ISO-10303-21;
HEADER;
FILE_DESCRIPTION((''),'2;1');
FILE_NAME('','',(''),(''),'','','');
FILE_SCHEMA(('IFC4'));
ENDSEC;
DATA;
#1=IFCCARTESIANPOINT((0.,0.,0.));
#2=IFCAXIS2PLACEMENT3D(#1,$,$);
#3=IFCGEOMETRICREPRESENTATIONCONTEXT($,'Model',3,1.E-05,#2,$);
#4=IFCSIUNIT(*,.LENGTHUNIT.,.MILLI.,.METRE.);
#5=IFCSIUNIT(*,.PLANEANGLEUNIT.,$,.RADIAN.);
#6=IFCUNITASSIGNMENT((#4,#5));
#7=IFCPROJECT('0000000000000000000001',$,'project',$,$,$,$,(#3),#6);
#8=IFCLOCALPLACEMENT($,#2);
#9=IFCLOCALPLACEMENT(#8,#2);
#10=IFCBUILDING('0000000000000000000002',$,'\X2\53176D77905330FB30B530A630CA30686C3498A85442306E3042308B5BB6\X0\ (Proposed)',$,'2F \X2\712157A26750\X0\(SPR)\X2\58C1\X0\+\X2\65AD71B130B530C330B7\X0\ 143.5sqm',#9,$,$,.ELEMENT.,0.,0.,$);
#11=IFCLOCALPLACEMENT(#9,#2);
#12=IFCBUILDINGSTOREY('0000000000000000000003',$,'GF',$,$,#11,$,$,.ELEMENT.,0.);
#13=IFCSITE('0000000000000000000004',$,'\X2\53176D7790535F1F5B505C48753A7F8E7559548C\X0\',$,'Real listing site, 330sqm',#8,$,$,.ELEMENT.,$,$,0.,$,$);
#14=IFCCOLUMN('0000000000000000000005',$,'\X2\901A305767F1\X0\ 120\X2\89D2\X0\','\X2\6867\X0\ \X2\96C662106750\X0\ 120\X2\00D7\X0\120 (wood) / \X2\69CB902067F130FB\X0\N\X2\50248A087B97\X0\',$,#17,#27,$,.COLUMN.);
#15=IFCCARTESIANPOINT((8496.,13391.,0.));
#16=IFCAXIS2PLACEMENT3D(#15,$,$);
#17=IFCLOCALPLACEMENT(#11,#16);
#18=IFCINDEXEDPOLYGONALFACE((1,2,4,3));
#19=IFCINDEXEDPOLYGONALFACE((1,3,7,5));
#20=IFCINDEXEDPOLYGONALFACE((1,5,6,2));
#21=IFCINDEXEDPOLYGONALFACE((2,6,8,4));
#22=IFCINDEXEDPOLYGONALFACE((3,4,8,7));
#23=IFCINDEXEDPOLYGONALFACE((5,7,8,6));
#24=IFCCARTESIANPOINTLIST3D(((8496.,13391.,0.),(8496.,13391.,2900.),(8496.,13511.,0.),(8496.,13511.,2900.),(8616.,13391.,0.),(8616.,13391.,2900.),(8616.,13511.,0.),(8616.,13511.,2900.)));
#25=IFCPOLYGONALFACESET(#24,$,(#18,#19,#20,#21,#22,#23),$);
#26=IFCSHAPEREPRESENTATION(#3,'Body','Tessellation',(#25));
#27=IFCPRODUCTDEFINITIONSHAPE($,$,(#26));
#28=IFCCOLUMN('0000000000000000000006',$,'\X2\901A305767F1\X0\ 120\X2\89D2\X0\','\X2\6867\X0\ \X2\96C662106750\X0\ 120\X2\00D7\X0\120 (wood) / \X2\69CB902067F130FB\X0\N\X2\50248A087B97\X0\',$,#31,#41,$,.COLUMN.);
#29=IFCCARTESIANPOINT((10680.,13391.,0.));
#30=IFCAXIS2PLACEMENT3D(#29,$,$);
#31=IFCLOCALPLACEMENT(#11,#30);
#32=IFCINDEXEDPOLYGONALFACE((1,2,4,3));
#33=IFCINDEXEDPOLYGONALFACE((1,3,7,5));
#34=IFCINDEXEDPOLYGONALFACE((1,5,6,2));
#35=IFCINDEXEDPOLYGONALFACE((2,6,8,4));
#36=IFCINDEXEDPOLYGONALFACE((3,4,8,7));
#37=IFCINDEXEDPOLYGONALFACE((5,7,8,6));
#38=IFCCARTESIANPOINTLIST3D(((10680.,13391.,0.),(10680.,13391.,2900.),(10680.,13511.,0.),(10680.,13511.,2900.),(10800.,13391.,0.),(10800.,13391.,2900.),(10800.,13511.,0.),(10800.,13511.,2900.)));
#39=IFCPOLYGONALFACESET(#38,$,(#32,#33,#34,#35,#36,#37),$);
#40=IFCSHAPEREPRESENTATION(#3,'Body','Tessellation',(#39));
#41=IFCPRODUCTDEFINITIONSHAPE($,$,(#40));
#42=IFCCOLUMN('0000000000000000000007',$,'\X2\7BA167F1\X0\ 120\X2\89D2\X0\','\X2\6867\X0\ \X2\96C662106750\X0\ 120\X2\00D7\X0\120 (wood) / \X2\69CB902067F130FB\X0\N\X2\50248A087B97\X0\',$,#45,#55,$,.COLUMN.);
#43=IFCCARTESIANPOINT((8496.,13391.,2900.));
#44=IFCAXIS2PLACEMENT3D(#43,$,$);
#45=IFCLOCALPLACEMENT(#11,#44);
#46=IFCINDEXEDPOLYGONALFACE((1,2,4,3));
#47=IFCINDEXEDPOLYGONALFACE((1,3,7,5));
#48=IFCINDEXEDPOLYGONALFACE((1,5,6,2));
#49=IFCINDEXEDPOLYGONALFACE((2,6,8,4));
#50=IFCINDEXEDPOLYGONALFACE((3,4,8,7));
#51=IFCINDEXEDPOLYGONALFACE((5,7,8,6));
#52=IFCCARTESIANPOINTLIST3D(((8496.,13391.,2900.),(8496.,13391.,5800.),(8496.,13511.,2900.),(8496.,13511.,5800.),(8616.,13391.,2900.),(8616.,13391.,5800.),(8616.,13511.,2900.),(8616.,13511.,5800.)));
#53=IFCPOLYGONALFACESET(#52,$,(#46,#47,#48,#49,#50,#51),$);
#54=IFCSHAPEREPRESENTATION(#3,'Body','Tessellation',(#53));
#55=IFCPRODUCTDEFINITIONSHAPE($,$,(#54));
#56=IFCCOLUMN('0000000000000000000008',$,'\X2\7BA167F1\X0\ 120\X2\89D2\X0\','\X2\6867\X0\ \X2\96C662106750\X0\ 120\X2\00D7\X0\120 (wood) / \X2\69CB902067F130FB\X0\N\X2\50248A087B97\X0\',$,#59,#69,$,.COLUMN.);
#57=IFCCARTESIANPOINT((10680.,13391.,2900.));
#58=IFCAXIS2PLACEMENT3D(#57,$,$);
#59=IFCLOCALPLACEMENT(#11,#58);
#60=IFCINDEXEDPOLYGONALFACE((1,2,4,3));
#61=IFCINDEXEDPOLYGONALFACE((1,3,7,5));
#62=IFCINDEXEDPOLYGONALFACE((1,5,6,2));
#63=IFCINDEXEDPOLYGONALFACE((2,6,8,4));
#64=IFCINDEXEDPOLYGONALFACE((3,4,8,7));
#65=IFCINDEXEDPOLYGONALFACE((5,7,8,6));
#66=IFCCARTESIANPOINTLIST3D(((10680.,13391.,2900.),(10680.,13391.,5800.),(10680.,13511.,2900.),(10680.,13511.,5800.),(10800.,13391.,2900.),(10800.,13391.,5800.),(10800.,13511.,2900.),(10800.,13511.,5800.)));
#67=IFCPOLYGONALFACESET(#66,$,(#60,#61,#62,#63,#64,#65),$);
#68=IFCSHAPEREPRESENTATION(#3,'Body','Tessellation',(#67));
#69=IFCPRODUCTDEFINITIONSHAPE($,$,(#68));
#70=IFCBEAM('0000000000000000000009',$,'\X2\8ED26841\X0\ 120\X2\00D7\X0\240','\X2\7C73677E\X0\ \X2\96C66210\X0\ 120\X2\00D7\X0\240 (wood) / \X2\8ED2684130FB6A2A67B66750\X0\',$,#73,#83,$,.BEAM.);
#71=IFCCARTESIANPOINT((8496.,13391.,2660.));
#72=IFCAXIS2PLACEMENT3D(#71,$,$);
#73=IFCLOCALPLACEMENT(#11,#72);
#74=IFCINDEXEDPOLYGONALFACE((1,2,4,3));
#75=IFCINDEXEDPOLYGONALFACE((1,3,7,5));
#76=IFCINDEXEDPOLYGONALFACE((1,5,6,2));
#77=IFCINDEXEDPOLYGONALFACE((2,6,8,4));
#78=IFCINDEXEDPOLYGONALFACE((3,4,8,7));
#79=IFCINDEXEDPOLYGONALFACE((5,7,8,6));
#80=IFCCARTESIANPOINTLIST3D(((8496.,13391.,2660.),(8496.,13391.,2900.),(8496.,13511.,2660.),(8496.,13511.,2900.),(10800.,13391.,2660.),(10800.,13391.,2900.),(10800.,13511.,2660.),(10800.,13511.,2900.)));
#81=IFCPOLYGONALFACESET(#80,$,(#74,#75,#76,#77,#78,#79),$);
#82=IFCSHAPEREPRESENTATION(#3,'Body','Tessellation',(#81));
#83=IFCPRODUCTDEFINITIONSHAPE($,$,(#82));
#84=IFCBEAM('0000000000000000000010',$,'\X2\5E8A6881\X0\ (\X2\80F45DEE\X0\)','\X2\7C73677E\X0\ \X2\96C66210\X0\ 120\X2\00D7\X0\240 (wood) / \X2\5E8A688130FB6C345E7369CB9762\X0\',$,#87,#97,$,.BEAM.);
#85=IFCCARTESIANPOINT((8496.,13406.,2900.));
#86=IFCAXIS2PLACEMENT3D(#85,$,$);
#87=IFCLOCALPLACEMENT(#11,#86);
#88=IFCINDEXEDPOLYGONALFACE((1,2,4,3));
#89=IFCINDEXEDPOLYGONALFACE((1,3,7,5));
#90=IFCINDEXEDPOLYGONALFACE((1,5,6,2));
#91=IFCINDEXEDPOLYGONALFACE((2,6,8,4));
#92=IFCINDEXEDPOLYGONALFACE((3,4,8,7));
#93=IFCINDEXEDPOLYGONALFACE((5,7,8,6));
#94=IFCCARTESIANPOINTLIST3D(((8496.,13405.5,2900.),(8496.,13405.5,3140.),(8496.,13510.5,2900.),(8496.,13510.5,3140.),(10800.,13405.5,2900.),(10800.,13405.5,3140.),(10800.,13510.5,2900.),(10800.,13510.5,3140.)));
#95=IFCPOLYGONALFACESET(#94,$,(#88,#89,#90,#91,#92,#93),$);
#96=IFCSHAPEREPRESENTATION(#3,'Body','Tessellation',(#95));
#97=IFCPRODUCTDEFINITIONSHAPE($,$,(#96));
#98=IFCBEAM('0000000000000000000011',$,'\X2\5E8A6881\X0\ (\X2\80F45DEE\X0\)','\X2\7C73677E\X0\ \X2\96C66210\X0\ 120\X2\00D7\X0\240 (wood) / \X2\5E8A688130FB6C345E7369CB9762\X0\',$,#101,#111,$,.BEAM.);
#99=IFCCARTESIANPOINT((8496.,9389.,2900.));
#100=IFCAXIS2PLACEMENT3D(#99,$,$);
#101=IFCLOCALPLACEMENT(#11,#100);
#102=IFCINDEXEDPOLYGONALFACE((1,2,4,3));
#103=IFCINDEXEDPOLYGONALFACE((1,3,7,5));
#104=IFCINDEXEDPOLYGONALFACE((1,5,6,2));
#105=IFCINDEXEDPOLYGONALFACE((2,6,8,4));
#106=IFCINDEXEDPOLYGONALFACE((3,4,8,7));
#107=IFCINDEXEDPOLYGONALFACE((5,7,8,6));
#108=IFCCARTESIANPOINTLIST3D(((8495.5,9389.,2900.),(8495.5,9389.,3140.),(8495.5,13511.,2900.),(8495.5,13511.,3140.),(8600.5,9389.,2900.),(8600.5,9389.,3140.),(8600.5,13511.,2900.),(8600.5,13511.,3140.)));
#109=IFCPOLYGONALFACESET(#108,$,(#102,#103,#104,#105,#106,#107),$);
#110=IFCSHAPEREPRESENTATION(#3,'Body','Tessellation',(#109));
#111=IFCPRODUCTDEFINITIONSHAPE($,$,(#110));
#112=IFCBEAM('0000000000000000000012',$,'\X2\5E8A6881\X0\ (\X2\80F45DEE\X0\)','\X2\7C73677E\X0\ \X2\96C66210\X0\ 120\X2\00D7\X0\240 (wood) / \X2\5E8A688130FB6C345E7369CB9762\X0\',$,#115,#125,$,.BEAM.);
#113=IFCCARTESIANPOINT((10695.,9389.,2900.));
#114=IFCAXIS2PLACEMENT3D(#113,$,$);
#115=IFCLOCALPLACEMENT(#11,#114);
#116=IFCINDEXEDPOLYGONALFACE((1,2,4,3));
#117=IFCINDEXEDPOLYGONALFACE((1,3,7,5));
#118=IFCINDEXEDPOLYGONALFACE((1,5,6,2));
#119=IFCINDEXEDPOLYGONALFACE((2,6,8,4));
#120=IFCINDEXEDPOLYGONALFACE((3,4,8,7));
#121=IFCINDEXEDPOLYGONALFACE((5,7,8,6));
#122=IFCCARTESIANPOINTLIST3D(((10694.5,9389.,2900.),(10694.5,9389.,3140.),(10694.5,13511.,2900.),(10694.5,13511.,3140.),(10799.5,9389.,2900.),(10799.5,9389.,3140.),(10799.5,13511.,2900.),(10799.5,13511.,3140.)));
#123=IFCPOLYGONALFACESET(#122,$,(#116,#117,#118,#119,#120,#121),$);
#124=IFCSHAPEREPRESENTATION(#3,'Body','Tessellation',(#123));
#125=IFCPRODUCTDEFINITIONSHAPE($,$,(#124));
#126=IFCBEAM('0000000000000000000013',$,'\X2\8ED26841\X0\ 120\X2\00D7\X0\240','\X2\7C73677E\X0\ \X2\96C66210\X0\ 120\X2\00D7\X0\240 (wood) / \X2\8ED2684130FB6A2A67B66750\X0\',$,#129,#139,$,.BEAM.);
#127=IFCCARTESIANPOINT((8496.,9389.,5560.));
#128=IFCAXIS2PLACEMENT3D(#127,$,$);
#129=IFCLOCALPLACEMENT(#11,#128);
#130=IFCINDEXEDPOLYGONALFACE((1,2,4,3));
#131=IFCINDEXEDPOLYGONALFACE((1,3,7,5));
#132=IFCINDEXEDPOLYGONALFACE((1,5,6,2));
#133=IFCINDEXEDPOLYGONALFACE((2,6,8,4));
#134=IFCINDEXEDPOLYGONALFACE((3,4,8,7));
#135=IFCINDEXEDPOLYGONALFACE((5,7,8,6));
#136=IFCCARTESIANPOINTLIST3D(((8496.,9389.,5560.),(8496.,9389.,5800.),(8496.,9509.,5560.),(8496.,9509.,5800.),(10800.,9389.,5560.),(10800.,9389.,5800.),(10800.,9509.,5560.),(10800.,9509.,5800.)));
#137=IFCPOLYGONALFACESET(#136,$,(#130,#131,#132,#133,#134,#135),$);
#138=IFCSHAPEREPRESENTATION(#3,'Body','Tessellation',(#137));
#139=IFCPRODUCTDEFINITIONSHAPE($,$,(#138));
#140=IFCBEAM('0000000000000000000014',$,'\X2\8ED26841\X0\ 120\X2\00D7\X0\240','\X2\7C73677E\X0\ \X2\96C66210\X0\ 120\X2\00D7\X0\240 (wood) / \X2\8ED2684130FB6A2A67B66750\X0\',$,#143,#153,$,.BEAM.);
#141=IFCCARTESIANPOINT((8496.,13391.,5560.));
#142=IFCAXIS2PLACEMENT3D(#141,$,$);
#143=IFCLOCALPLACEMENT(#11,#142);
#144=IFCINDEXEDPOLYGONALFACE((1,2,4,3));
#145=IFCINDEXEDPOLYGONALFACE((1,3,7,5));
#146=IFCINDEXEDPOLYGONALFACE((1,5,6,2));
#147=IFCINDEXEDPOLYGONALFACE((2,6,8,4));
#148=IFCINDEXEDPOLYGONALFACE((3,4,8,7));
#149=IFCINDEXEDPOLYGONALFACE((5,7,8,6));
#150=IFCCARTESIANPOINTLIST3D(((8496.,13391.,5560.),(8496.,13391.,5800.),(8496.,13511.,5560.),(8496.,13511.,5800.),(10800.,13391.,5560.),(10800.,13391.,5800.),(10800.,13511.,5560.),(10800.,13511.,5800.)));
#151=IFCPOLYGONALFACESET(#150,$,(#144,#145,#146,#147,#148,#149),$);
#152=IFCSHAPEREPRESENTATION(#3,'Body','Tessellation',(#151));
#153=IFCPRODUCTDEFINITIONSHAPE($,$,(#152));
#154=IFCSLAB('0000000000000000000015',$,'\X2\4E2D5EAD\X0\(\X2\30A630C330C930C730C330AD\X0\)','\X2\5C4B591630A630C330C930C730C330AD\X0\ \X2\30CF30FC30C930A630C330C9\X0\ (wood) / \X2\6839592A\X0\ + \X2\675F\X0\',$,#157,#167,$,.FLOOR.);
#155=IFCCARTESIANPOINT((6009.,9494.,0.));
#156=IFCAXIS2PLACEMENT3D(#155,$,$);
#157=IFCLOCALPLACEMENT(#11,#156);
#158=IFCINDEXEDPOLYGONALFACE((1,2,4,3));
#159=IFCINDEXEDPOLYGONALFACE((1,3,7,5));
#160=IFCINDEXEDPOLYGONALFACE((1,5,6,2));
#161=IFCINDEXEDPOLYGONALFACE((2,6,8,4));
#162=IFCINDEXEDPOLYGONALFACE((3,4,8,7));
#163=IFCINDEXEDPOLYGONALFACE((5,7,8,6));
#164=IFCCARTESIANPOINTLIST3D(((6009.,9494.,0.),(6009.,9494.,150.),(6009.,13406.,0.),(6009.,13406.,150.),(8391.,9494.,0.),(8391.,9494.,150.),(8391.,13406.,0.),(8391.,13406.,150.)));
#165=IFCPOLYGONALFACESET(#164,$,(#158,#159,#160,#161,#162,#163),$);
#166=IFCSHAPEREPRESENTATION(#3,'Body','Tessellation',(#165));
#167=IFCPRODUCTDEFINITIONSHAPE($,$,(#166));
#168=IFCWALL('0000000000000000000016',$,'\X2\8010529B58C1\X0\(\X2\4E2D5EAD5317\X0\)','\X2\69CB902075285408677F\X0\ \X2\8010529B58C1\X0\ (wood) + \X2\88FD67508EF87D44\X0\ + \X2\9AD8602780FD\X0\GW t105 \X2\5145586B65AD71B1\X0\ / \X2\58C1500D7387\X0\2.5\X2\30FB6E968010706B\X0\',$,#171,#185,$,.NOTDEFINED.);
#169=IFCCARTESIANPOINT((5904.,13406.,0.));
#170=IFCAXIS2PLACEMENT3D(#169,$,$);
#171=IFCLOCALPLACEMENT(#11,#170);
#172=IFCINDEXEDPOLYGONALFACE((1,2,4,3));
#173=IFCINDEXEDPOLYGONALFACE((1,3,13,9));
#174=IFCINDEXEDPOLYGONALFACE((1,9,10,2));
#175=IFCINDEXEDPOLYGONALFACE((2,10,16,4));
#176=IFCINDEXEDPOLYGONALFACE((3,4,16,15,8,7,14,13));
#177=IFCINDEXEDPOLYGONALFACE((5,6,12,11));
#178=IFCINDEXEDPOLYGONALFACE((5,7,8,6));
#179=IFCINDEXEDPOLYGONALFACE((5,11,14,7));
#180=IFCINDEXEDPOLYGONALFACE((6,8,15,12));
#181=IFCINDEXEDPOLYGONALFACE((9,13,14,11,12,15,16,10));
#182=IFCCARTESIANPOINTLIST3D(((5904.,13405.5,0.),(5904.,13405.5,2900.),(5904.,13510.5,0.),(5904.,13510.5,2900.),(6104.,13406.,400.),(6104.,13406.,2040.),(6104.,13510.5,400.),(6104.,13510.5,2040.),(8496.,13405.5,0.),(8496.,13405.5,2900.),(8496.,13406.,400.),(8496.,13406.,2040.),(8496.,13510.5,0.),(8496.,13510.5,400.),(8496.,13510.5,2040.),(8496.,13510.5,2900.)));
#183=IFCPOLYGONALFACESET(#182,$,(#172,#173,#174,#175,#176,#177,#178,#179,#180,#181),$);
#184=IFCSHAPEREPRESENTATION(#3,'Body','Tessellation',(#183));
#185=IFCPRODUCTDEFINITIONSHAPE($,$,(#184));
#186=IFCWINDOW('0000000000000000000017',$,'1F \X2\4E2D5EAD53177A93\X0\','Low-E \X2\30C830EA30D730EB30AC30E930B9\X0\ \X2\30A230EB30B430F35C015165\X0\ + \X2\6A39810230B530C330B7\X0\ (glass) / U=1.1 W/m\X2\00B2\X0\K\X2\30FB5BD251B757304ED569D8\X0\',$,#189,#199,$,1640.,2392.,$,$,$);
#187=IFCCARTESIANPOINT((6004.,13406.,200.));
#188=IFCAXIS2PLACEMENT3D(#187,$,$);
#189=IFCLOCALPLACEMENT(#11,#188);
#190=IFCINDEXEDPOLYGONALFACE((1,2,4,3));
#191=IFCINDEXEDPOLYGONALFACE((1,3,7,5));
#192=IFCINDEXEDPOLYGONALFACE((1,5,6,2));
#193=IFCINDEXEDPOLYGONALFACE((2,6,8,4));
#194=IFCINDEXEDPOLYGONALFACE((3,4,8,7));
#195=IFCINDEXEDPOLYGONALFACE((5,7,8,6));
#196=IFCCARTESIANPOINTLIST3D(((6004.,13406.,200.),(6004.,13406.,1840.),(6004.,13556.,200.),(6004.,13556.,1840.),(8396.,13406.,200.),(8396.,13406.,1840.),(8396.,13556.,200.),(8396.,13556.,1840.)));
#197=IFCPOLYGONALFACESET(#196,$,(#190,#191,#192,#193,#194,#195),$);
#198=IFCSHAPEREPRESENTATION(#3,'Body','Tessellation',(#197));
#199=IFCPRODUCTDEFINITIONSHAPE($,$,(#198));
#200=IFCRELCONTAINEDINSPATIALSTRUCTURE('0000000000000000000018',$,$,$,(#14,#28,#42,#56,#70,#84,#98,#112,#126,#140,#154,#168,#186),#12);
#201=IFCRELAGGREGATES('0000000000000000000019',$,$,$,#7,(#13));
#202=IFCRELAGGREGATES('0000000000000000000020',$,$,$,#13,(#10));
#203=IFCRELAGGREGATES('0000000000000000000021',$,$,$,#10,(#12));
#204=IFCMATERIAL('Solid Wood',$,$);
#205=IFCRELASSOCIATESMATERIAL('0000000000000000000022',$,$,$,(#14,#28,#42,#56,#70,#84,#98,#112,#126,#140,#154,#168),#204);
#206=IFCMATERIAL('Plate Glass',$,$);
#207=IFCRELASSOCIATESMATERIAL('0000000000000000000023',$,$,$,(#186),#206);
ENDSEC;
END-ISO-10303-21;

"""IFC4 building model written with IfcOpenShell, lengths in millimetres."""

from ifc_helpers import new_model, si_unit, frame, frame_2d, origin, place, context, project, spatial, rectangle, extrude, material, element, fill, save


model = new_model("IFC4")

# Units and contexts
model_context = context("Model", 3, precision=1e-05, world=origin())
ifc_project = project(units=[si_unit("LENGTHUNIT", "METRE", prefix="MILLI"), si_unit("PLANEANGLEUNIT", "RADIAN")], contexts=[model_context])

# Site, building, storey
site_placement = place(None, origin())
site = spatial("IfcSite", under=ifc_project, at=site_placement, Name="北海道弟子屈町美留和", ObjectType="Real listing site, 330sqm", CompositionType="ELEMENT", RefElevation=0.0)
building_placement = place(site_placement, origin())
building = spatial("IfcBuilding", under=site, at=building_placement, Name="北海道・サウナと水風呂のある家 (Proposed)", ObjectType="2F 無垢材(SPR)壁+断熱サッシ 143.5sqm", CompositionType="ELEMENT", ElevationOfRefHeight=0.0, ElevationOfTerrain=0.0)
storey_placement = place(building_placement, origin())
storey = spatial("IfcBuildingStorey", under=building, at=storey_placement, Name="GF", CompositionType="ELEMENT", Elevation=0.0)

# Columns
ifc_material_1 = material(Name="Solid Wood")
column_1_placement = place(storey_placement, frame((8496.0, 13391.0, 0.0)))
element("IfcColumn", 1, at=column_1_placement, inside=storey, material=ifc_material_1, Name="通し柱 120角", Description="桧 集成材 120×120 (wood) / 構造柱・N値計算", PredefinedType="COLUMN", context=model_context, shape_type="SweptSolid", body=[
    extrude(rectangle(XDim=120.0, YDim=120.0, at=frame_2d((60.0, 60.0))), frame((8496.0, 13391.0, 0.0)), (0.0, 0.0, 1.0), 2900.0),
])
column_2_placement = place(storey_placement, frame((10680.0, 13391.0, 0.0)))
element("IfcColumn", 2, at=column_2_placement, inside=storey, material=ifc_material_1, Name="通し柱 120角", Description="桧 集成材 120×120 (wood) / 構造柱・N値計算", PredefinedType="COLUMN", context=model_context, shape_type="SweptSolid", body=[
    extrude(rectangle(XDim=120.0, YDim=120.0, at=frame_2d((60.0, 60.0))), frame((10680.0, 13391.0, 0.0)), (0.0, 0.0, 1.0), 2900.0),
])
column_3_placement = place(storey_placement, frame((8496.0, 13391.0, 2900.0)))
element("IfcColumn", 3, at=column_3_placement, inside=storey, material=ifc_material_1, Name="管柱 120角", Description="桧 集成材 120×120 (wood) / 構造柱・N値計算", PredefinedType="COLUMN", context=model_context, shape_type="SweptSolid", body=[
    extrude(rectangle(XDim=120.0, YDim=120.0, at=frame_2d((60.0, 60.0))), frame((8496.0, 13391.0, 2900.0)), (0.0, 0.0, 1.0), 2900.0),
])
column_4_placement = place(storey_placement, frame((10680.0, 13391.0, 2900.0)))
element("IfcColumn", 4, at=column_4_placement, inside=storey, material=ifc_material_1, Name="管柱 120角", Description="桧 集成材 120×120 (wood) / 構造柱・N値計算", PredefinedType="COLUMN", context=model_context, shape_type="SweptSolid", body=[
    extrude(rectangle(XDim=120.0, YDim=120.0, at=frame_2d((60.0, 60.0))), frame((10680.0, 13391.0, 2900.0)), (0.0, 0.0, 1.0), 2900.0),
])

# Beams
beam_1_placement = place(storey_placement, frame((8496.0, 13391.0, 2660.0)))
element("IfcBeam", 5, at=beam_1_placement, inside=storey, material=ifc_material_1, Name="軒桁 120×240", Description="米松 集成 120×240 (wood) / 軒桁・横架材", PredefinedType="BEAM", context=model_context, shape_type="SweptSolid", body=[
    extrude(rectangle(XDim=2304.0, YDim=120.0, at=frame_2d((1152.0, 60.0))), frame((8496.0, 13391.0, 2660.0)), (0.0, 0.0, 1.0), 240.0),
])
beam_2_placement = place(storey_placement, frame((8496.0, 13406.0, 2900.0)))
element("IfcBeam", 6, at=beam_2_placement, inside=storey, material=ifc_material_1, Name="床梁 (胴差)", Description="米松 集成 120×240 (wood) / 床梁・水平構面", PredefinedType="BEAM", context=model_context, shape_type="SweptSolid", body=[
    extrude(rectangle(XDim=2304.0, YDim=105.0, at=frame_2d((1152.0, 52.0))), frame((8496.0, 13406.0, 2900.0)), (0.0, 0.0, 1.0), 240.0),
])
beam_3_placement = place(storey_placement, frame((8496.0, 9389.0, 2900.0)))
element("IfcBeam", 7, at=beam_3_placement, inside=storey, material=ifc_material_1, Name="床梁 (胴差)", Description="米松 集成 120×240 (wood) / 床梁・水平構面", PredefinedType="BEAM", context=model_context, shape_type="SweptSolid", body=[
    extrude(rectangle(XDim=105.0, YDim=4122.0, at=frame_2d((52.0, 2061.0))), frame((8496.0, 9389.0, 2900.0)), (0.0, 0.0, 1.0), 240.0),
])
beam_4_placement = place(storey_placement, frame((10695.0, 9389.0, 2900.0)))
element("IfcBeam", 8, at=beam_4_placement, inside=storey, material=ifc_material_1, Name="床梁 (胴差)", Description="米松 集成 120×240 (wood) / 床梁・水平構面", PredefinedType="BEAM", context=model_context, shape_type="SweptSolid", body=[
    extrude(rectangle(XDim=105.0, YDim=4122.0, at=frame_2d((52.0, 2061.0))), frame((10695.0, 9389.0, 2900.0)), (0.0, 0.0, 1.0), 240.0),
])
beam_5_placement = place(storey_placement, frame((8496.0, 9389.0, 5560.0)))
element("IfcBeam", 9, at=beam_5_placement, inside=storey, material=ifc_material_1, Name="軒桁 120×240", Description="米松 集成 120×240 (wood) / 軒桁・横架材", PredefinedType="BEAM", context=model_context, shape_type="SweptSolid", body=[
    extrude(rectangle(XDim=2304.0, YDim=120.0, at=frame_2d((1152.0, 60.0))), frame((8496.0, 9389.0, 5560.0)), (0.0, 0.0, 1.0), 240.0),
])
beam_6_placement = place(storey_placement, frame((8496.0, 13391.0, 5560.0)))
element("IfcBeam", 10, at=beam_6_placement, inside=storey, material=ifc_material_1, Name="軒桁 120×240", Description="米松 集成 120×240 (wood) / 軒桁・横架材", PredefinedType="BEAM", context=model_context, shape_type="SweptSolid", body=[
    extrude(rectangle(XDim=2304.0, YDim=120.0, at=frame_2d((1152.0, 60.0))), frame((8496.0, 13391.0, 5560.0)), (0.0, 0.0, 1.0), 240.0),
])

# Slab
slab_placement = place(storey_placement, frame((6009.0, 9494.0, 0.0)))
element("IfcSlab", 11, at=slab_placement, inside=storey, material=ifc_material_1, Name="中庭(ウッドデッキ)", Description="屋外ウッドデッキ ハードウッド (wood) / 根太 + 束", PredefinedType="FLOOR", context=model_context, shape_type="SweptSolid", body=[
    extrude(rectangle(XDim=2382.0, YDim=3912.0, at=frame_2d((1191.0, 1956.0))), frame((6009.0, 9494.0, 0.0)), (0.0, 0.0, 1.0), 150.0),
])

# Wall, opening, window
wall_1_placement = place(storey_placement, frame((5904.0, 13406.0, 0.0)))
wall_1 = element("IfcWall", 12, at=wall_1_placement, inside=storey, material=ifc_material_1, Name="耐力壁(中庭北)", Description="構造用合板 耐力壁 (wood) + 製材軸組 + 高性能GW t105 充填断熱 / 壁倍率2.5・準耐火", PredefinedType="NOTDEFINED", context=model_context, shape_type="SweptSolid", body=[
    extrude(rectangle(XDim=2592.0, YDim=105.0, at=frame_2d((1296.0, 52.0))), frame((5904.0, 13406.0, 0.0)), (0.0, 0.0, 1.0), 2900.0),
])
opening_1_placement = place(storey_placement, frame((6004.0, 13406.0, 200.0)))
opening_1 = element("IfcOpeningElement", 13, at=opening_1_placement, cuts=wall_1, PredefinedType="NOTDEFINED", context=model_context, shape_type="SweptSolid", body=[
    extrude(rectangle(XDim=2392.0, YDim=150.0, at=frame_2d((1196.0, 75.0))), frame((6004.0, 13406.0, 200.0)), (0.0, 0.0, 1.0), 1640.0),
])
ifc_material_2 = material(Name="Plate Glass")
window_1_placement = place(storey_placement, frame((6004.0, 13406.0, 200.0)))
window_1 = element("IfcWindow", 14, at=window_1_placement, inside=storey, material=ifc_material_2, Name="1F 中庭北窓", Description="Low-E トリプルガラス アルゴン封入 + 樹脂サッシ (glass) / U=1.1 W/m²K・寒冷地仕様", OverallHeight=1640.0, OverallWidth=2392.0, context=model_context, shape_type="SweptSolid", body=[
    extrude(rectangle(XDim=2392.0, YDim=150.0, at=frame_2d((1196.0, 75.0))), frame((6004.0, 13406.0, 200.0)), (0.0, 0.0, 1.0), 1640.0),
])
fill(opening_1, window_1)

save(model, "model.ifc")
